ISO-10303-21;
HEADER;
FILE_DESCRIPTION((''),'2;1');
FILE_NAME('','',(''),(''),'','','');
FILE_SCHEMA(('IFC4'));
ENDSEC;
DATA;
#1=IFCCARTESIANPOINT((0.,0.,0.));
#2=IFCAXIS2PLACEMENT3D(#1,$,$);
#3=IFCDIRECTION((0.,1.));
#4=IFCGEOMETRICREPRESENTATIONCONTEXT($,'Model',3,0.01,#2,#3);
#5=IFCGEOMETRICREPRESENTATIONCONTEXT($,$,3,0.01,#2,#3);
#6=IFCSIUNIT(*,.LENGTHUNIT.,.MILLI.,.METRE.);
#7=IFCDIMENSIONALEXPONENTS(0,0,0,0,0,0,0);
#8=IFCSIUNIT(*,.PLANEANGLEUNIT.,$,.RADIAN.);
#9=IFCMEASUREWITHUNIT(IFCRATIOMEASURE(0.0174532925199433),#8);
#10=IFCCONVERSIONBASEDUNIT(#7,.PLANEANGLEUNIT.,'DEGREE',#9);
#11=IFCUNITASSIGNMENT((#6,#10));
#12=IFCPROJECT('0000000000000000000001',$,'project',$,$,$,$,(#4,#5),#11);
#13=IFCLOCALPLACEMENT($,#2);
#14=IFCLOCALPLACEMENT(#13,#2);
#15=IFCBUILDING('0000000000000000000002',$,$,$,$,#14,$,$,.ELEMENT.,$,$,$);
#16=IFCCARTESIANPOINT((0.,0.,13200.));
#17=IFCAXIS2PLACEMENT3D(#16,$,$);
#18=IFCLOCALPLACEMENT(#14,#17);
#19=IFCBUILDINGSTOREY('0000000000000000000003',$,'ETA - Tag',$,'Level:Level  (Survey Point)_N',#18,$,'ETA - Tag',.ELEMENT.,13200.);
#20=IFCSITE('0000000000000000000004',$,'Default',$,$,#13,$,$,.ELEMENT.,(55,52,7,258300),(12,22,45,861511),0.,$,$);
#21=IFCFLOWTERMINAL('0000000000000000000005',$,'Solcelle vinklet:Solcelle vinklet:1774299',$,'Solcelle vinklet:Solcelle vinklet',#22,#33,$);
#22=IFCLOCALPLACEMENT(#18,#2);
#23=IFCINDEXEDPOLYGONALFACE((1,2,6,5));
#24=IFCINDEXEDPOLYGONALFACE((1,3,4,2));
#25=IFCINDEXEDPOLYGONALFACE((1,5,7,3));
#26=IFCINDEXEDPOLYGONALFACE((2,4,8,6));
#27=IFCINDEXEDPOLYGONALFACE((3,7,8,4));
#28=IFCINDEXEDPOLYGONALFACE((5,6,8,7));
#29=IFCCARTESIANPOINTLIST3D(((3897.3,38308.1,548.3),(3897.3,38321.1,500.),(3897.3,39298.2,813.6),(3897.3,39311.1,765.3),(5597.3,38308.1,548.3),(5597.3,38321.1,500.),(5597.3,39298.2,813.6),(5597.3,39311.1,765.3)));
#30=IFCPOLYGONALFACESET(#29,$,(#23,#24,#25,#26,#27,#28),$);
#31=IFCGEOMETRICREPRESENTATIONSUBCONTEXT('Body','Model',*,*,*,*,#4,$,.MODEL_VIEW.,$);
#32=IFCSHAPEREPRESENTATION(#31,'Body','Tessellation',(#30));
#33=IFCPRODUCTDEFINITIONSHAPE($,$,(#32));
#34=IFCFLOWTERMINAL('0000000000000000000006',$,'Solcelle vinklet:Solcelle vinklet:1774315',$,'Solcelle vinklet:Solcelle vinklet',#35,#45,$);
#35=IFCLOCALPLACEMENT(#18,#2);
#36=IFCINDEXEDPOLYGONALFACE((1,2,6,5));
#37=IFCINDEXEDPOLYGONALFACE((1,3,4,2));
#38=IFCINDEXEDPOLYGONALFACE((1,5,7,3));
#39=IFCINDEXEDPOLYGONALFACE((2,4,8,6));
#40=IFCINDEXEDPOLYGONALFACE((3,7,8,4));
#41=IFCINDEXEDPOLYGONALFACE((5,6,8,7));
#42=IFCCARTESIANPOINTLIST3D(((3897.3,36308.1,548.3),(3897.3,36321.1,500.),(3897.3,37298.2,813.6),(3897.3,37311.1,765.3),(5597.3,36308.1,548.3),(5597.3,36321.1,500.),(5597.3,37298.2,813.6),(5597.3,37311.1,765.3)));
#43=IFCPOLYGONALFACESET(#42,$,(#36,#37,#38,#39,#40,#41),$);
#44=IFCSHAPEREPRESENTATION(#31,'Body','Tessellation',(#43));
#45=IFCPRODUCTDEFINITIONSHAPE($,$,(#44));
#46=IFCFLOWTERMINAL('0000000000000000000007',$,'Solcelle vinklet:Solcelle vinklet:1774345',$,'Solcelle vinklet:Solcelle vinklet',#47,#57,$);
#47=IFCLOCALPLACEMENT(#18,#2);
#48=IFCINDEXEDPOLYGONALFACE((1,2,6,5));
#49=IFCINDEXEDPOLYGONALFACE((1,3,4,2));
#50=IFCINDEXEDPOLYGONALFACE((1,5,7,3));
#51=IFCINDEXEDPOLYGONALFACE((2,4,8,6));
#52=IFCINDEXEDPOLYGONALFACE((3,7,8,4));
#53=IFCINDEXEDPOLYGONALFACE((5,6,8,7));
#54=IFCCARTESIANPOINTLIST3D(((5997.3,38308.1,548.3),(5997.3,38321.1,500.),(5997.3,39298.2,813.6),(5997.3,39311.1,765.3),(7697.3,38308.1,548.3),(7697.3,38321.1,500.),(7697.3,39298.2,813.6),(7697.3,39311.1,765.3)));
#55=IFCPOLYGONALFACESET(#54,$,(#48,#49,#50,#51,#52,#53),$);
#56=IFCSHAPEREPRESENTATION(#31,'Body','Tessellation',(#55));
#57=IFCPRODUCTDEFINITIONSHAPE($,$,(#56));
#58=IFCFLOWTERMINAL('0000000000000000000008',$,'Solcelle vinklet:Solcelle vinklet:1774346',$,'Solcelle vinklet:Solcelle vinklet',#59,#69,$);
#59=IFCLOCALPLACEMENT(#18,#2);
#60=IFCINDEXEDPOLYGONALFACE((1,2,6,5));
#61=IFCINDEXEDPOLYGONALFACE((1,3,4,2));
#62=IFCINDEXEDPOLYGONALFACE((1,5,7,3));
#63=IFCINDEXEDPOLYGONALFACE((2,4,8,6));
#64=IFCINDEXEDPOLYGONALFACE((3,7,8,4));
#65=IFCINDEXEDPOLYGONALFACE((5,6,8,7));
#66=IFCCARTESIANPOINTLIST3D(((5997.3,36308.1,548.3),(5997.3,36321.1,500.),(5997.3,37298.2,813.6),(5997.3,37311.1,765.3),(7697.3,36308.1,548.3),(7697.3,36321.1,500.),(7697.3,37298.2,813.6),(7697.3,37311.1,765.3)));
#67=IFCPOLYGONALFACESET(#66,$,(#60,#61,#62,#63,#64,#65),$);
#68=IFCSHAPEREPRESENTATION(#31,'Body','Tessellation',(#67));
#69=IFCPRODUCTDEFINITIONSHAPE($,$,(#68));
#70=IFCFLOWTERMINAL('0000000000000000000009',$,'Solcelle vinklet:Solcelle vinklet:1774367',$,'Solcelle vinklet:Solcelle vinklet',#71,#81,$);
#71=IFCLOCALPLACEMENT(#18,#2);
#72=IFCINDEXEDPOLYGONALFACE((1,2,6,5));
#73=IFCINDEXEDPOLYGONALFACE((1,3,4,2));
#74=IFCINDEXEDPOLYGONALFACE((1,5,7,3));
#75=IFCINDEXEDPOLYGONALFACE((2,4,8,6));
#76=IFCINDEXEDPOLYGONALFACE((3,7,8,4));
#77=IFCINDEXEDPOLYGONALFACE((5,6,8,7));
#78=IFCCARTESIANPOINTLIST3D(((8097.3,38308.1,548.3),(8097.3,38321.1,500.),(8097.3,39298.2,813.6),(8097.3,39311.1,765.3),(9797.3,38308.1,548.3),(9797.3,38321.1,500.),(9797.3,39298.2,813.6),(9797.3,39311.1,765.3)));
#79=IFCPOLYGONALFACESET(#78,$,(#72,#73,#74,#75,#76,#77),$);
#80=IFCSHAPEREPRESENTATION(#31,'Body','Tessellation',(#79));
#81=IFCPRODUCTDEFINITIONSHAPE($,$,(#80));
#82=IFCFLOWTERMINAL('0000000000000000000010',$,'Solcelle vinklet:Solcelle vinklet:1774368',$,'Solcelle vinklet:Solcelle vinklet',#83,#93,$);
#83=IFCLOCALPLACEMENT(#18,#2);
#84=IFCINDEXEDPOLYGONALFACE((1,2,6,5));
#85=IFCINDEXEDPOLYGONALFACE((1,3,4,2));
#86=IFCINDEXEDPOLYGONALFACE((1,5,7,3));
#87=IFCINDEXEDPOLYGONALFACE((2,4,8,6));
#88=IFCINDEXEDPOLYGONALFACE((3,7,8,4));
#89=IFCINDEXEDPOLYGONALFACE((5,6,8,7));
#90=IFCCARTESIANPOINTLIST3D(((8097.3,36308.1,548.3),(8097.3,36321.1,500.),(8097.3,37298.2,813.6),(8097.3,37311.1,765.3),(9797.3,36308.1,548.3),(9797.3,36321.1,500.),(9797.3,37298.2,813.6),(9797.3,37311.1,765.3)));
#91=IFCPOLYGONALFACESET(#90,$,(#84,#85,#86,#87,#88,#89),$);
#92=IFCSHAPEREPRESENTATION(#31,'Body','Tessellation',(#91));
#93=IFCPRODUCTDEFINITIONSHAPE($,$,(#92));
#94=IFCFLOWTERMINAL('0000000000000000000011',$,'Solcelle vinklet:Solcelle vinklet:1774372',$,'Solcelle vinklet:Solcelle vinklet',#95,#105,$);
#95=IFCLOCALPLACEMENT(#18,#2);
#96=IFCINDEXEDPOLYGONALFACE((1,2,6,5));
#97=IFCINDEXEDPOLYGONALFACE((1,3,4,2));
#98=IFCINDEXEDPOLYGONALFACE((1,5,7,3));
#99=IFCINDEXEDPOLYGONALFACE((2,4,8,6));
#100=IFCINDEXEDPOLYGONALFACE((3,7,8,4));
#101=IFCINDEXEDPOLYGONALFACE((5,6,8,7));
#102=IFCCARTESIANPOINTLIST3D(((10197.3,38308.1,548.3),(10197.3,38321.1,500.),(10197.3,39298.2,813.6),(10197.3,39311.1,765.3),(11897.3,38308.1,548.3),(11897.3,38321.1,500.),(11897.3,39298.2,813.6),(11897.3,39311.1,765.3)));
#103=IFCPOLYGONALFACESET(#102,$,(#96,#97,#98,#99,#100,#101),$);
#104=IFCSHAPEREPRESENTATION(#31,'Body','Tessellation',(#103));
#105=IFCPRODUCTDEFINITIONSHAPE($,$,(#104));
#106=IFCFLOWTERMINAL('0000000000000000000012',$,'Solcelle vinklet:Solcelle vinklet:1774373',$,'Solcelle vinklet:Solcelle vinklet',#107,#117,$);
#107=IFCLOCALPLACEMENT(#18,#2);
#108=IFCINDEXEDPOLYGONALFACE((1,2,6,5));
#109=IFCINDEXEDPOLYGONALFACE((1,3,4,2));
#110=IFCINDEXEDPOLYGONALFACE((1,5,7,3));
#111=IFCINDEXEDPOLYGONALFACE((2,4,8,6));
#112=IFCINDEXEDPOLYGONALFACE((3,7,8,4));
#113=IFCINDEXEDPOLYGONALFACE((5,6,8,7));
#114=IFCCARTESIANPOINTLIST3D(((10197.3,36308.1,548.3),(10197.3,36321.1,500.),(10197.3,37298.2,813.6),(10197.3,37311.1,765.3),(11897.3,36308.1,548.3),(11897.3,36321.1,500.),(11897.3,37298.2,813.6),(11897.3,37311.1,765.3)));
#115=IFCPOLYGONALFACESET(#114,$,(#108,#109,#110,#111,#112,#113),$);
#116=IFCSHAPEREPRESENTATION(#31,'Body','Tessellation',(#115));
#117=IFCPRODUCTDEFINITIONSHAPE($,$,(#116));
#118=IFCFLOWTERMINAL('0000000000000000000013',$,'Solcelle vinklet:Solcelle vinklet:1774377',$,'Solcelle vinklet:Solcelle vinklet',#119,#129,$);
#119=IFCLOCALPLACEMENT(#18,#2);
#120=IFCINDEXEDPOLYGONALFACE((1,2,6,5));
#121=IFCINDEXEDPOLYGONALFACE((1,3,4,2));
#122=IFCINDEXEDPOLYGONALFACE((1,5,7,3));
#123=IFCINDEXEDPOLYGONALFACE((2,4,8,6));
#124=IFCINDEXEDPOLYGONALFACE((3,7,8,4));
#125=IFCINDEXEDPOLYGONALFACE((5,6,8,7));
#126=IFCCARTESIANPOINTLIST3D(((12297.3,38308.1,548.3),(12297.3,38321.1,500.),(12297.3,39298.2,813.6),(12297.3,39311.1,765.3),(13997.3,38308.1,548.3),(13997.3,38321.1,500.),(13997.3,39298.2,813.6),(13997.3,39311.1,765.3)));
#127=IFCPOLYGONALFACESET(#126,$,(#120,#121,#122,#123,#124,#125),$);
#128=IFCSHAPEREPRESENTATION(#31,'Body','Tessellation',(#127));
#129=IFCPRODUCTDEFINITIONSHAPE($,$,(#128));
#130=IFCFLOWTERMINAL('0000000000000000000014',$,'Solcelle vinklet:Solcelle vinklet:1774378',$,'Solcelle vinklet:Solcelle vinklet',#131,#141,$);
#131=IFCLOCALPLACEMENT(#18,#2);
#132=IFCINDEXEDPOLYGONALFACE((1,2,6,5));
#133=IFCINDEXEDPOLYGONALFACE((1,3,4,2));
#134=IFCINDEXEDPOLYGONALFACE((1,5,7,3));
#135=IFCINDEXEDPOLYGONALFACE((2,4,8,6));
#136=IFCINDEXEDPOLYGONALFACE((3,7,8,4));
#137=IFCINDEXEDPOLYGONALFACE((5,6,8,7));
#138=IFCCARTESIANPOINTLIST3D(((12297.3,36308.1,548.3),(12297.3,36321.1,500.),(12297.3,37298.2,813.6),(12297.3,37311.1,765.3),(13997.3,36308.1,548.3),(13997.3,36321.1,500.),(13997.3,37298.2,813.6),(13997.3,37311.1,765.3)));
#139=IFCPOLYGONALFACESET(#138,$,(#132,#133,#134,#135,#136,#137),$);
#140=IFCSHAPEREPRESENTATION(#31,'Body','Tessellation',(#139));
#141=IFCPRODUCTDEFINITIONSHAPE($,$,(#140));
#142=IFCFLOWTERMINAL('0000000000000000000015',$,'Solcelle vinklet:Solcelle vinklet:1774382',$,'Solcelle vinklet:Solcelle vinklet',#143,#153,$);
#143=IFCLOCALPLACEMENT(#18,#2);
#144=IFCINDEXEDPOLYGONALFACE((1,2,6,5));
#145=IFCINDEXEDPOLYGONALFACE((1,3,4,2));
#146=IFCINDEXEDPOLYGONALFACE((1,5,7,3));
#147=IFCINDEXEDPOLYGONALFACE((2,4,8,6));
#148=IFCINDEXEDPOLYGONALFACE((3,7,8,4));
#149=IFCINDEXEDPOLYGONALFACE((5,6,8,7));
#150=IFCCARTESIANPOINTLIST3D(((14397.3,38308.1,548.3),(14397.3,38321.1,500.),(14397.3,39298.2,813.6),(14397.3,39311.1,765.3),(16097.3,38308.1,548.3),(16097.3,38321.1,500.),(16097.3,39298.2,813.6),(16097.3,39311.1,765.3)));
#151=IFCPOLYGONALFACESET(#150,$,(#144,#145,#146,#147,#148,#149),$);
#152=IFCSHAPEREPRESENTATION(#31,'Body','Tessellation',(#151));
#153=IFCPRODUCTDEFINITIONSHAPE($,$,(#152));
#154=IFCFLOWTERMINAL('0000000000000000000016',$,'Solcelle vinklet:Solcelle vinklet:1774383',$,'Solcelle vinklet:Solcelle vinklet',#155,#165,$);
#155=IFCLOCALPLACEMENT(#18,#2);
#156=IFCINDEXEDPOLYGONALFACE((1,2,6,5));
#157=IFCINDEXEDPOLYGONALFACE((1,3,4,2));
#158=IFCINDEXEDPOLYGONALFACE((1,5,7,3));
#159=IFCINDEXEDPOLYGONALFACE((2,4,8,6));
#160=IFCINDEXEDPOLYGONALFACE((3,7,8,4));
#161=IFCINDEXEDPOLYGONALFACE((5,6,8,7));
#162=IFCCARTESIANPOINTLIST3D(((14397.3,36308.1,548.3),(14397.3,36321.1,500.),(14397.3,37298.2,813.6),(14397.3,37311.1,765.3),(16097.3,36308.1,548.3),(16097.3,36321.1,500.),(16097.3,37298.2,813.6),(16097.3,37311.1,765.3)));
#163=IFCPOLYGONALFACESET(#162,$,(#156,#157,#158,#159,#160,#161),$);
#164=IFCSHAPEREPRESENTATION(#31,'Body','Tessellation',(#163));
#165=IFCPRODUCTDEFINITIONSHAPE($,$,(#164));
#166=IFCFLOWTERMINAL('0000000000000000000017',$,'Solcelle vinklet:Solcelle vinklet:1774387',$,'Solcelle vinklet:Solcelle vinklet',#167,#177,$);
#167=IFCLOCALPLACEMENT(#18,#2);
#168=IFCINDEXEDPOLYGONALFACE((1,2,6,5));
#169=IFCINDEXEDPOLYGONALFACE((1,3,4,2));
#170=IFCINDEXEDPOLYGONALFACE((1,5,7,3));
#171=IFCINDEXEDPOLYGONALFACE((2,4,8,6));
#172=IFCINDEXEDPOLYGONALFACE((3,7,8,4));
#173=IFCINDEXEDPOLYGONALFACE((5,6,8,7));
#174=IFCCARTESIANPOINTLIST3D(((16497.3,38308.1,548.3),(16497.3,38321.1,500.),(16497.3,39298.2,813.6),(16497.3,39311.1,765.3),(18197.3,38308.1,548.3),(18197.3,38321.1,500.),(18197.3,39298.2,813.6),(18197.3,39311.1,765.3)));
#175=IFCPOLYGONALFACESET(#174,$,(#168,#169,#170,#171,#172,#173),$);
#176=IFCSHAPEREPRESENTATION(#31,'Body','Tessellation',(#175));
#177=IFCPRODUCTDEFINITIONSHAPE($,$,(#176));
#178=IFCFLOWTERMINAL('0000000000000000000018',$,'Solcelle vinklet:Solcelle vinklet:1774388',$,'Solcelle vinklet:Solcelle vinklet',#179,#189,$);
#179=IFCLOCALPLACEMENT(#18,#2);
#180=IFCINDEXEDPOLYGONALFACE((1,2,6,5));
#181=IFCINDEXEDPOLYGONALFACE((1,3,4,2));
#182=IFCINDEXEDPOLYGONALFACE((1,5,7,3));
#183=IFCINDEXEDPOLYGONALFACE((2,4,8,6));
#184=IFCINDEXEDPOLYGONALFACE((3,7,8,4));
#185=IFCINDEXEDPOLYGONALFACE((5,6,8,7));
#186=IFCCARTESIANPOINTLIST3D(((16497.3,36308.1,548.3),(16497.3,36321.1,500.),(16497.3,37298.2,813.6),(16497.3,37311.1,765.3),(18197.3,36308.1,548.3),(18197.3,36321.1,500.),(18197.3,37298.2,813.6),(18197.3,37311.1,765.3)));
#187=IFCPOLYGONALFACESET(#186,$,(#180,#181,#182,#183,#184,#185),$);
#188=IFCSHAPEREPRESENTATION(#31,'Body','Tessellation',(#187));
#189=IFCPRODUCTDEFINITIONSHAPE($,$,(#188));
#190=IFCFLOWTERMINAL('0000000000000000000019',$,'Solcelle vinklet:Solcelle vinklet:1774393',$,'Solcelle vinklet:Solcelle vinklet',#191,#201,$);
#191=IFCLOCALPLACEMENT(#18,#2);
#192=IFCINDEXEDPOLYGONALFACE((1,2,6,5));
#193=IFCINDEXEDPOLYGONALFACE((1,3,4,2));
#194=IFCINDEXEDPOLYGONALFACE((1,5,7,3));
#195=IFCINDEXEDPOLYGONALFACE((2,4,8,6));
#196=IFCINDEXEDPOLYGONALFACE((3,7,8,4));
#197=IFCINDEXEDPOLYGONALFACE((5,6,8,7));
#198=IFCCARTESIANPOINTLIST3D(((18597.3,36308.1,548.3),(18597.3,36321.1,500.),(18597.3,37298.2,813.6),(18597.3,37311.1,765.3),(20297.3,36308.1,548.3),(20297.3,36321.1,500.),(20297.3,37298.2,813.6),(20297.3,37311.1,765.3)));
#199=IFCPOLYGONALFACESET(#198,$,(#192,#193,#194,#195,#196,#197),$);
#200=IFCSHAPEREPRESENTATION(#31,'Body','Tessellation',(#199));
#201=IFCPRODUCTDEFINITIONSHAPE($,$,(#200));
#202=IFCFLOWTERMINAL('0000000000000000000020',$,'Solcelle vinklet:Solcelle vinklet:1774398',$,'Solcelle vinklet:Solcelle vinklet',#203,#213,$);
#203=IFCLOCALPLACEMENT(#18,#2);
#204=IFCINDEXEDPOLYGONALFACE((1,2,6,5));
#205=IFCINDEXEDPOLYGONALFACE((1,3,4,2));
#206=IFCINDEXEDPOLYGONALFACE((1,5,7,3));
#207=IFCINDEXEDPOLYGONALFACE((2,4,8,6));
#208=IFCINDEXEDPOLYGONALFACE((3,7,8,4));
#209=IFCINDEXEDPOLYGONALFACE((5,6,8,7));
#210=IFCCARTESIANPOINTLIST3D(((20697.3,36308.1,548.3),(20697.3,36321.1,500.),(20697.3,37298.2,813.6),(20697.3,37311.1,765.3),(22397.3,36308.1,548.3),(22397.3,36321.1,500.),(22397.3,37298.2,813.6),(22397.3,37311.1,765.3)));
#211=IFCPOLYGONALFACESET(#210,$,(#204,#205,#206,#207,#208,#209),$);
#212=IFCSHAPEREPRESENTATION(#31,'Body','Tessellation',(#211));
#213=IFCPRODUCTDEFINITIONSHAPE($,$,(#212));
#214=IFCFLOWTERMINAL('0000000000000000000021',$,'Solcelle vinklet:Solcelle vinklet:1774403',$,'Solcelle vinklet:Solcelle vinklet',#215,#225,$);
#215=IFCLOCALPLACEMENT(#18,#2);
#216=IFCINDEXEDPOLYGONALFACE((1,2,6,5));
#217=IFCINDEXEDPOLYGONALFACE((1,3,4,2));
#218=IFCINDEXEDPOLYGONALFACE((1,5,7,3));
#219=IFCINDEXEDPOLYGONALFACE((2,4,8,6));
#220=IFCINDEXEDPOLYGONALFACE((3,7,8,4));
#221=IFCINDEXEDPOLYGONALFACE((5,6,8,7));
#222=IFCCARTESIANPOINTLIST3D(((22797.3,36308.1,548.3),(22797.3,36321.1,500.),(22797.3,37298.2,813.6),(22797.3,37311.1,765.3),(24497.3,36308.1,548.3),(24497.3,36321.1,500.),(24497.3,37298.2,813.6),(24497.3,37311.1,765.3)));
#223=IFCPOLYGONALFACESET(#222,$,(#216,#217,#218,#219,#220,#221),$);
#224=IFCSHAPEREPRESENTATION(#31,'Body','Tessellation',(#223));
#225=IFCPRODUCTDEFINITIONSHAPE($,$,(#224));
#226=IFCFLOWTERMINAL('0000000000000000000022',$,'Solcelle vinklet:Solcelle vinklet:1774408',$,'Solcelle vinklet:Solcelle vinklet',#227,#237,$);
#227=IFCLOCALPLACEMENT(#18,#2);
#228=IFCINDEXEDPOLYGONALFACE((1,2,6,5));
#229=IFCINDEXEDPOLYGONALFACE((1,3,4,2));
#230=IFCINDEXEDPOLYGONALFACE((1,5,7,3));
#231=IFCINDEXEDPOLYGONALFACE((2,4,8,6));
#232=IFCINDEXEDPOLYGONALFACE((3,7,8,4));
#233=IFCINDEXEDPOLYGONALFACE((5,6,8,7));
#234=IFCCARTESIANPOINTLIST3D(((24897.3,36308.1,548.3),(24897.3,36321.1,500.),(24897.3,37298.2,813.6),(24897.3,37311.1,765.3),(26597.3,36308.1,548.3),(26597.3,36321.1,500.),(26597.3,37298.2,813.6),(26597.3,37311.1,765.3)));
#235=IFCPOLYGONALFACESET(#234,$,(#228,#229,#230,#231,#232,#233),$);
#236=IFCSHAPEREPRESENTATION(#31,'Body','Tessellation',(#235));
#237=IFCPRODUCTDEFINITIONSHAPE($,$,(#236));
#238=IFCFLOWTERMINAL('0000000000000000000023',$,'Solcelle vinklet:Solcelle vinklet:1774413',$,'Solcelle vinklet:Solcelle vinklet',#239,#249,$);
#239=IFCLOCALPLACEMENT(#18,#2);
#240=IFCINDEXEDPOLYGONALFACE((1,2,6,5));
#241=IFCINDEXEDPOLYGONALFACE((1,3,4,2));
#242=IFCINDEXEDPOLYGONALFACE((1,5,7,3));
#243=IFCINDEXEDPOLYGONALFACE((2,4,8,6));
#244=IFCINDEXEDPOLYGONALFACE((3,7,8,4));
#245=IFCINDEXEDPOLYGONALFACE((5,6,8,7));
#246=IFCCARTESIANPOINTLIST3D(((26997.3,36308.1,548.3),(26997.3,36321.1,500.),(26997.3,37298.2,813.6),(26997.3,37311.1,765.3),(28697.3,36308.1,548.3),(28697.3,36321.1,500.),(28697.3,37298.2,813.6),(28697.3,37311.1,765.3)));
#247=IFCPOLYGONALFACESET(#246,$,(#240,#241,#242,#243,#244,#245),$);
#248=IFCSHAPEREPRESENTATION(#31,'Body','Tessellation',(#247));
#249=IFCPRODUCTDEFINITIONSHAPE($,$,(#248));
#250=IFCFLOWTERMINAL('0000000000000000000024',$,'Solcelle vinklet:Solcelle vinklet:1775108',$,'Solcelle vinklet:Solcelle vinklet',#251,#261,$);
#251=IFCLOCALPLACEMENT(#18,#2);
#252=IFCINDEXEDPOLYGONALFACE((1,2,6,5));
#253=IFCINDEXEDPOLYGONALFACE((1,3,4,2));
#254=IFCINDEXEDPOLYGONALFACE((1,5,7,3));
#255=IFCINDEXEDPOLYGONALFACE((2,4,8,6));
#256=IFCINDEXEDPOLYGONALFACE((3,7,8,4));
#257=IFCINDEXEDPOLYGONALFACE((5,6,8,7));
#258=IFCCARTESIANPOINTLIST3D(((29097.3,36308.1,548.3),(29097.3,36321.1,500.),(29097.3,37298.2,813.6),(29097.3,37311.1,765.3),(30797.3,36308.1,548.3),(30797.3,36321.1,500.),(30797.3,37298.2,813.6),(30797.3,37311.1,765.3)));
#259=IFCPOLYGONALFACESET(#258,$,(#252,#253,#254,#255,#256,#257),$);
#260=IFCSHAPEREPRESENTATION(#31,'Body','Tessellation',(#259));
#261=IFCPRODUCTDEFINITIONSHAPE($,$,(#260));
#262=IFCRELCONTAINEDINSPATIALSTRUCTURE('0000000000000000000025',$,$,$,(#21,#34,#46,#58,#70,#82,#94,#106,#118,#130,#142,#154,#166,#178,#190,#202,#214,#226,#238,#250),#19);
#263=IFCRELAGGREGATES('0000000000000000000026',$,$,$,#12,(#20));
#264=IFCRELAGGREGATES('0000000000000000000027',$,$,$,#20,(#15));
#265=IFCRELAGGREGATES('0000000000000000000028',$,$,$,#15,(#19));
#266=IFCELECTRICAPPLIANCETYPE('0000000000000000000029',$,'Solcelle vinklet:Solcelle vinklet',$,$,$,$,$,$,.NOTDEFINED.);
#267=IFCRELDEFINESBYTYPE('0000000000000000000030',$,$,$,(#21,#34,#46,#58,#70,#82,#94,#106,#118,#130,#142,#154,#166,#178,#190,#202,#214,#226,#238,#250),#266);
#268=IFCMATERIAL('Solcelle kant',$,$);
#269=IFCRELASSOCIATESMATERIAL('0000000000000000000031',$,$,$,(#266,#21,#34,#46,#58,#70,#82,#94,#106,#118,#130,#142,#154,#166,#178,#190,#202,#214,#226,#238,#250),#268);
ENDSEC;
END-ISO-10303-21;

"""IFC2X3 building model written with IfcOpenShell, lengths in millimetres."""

from ifc_helpers import new_model, entity, si_unit, converted_unit, direction, frame, frame_2d, origin, place, context, subcontext, project, spatial, rectangle, extrude, source, transform, mapped, material, type_object, type_shapes, element, save


model = new_model("IFC2X3")

# Units and contexts
model_context = context("Model", 3, precision=0.01, world=origin(), true_north=direction((0.0, 1.0)))
context_of_model = context(None, 3, precision=0.01, world=origin(), true_north=direction((0.0, 1.0)))
body_context = subcontext(model_context, "Body", "Model", "MODEL_VIEW")
ifc_project = project(units=[si_unit("LENGTHUNIT", "METRE", prefix="MILLI"), converted_unit("PLANEANGLEUNIT", "DEGREE", entity("IfcRatioMeasure", 0.0174532925199433), si_unit("PLANEANGLEUNIT", "RADIAN"), dimensions=[0, 0, 0, 0, 0, 0, 0])], contexts=[model_context, context_of_model])

# Site, building, storey
site_placement = place(None, origin())
site = spatial("IfcSite", under=ifc_project, at=site_placement, Name="Default", CompositionType="ELEMENT", RefLatitude=(55, 52, 7, 258300), RefLongitude=(12, 22, 45, 861511), RefElevation=0.0)
building_placement = place(site_placement, origin())
building = spatial("IfcBuilding", under=site, at=building_placement, CompositionType="ELEMENT")
storey_placement = place(building_placement, frame((0.0, 0.0, 13200.0)))
storey = spatial("IfcBuildingStorey", under=building, at=storey_placement, Name="ETA - Tag", ObjectType="Level:Level  (Survey Point)_N", LongName="ETA - Tag", CompositionType="ELEMENT", Elevation=13200.0)

# Flow terminals
ifc_material = material(Name="Solcelle kant")
electric_appliance_type = type_object("IfcElectricApplianceType", Name="Solcelle vinklet:Solcelle vinklet", PredefinedType="NOTDEFINED", material=ifc_material)
shared_shape = source(origin(), body_context, "Body", "SweptSolid", [
    extrude(rectangle(XDim=50.0, YDim=1025.0, at=frame_2d((0.0, 0.0), x_axis=(1.0, 0.0))), frame((-850.0, 488.6, 156.8), z_axis=(1.0, 0.0, 0.0), x_axis=(0.0, 0.258819, -0.965926)), (0.0, 0.0, 1.0), 1700.0),
])
type_shapes(electric_appliance_type, [shared_shape])
for number, where, name in (
    (1, (4747.3, 38321.1, 500.0), "Solcelle vinklet:Solcelle vinklet:1774299"),
    (2, (4747.3, 36321.1, 500.0), "Solcelle vinklet:Solcelle vinklet:1774315"),
    (3, (6847.3, 38321.1, 500.0), "Solcelle vinklet:Solcelle vinklet:1774345"),
    (4, (6847.3, 36321.1, 500.0), "Solcelle vinklet:Solcelle vinklet:1774346"),
    (5, (8947.3, 38321.1, 500.0), "Solcelle vinklet:Solcelle vinklet:1774367"),
    (6, (8947.3, 36321.1, 500.0), "Solcelle vinklet:Solcelle vinklet:1774368"),
    (7, (11047.3, 38321.1, 500.0), "Solcelle vinklet:Solcelle vinklet:1774372"),
    (8, (11047.3, 36321.1, 500.0), "Solcelle vinklet:Solcelle vinklet:1774373"),
    (9, (13147.3, 38321.1, 500.0), "Solcelle vinklet:Solcelle vinklet:1774377"),
    (10, (13147.3, 36321.1, 500.0), "Solcelle vinklet:Solcelle vinklet:1774378"),
    (11, (15247.3, 38321.1, 500.0), "Solcelle vinklet:Solcelle vinklet:1774382"),
    (12, (15247.3, 36321.1, 500.0), "Solcelle vinklet:Solcelle vinklet:1774383"),
    (13, (17347.3, 38321.1, 500.0), "Solcelle vinklet:Solcelle vinklet:1774387"),
    (14, (17347.3, 36321.1, 500.0), "Solcelle vinklet:Solcelle vinklet:1774388"),
    (15, (19447.3, 36321.1, 500.0), "Solcelle vinklet:Solcelle vinklet:1774393"),
    (16, (21547.3, 36321.1, 500.0), "Solcelle vinklet:Solcelle vinklet:1774398"),
    (17, (23647.3, 36321.1, 500.0), "Solcelle vinklet:Solcelle vinklet:1774403"),
    (18, (25747.3, 36321.1, 500.0), "Solcelle vinklet:Solcelle vinklet:1774408"),
    (19, (27847.3, 36321.1, 500.0), "Solcelle vinklet:Solcelle vinklet:1774413"),
    (20, (29947.3, 36321.1, 500.0), "Solcelle vinklet:Solcelle vinklet:1775108"),
):
    element("IfcFlowTerminal", number, at=place(storey_placement, frame(where)), inside=storey, type_object=electric_appliance_type, material=ifc_material, Name=name, ObjectType="Solcelle vinklet:Solcelle vinklet", context=body_context, shape_type="MappedRepresentation", body=[
        mapped(shared_shape, transform((0.0, 0.0, 0.0), scale=1.0)),
    ])

save(model, "model.ifc")
